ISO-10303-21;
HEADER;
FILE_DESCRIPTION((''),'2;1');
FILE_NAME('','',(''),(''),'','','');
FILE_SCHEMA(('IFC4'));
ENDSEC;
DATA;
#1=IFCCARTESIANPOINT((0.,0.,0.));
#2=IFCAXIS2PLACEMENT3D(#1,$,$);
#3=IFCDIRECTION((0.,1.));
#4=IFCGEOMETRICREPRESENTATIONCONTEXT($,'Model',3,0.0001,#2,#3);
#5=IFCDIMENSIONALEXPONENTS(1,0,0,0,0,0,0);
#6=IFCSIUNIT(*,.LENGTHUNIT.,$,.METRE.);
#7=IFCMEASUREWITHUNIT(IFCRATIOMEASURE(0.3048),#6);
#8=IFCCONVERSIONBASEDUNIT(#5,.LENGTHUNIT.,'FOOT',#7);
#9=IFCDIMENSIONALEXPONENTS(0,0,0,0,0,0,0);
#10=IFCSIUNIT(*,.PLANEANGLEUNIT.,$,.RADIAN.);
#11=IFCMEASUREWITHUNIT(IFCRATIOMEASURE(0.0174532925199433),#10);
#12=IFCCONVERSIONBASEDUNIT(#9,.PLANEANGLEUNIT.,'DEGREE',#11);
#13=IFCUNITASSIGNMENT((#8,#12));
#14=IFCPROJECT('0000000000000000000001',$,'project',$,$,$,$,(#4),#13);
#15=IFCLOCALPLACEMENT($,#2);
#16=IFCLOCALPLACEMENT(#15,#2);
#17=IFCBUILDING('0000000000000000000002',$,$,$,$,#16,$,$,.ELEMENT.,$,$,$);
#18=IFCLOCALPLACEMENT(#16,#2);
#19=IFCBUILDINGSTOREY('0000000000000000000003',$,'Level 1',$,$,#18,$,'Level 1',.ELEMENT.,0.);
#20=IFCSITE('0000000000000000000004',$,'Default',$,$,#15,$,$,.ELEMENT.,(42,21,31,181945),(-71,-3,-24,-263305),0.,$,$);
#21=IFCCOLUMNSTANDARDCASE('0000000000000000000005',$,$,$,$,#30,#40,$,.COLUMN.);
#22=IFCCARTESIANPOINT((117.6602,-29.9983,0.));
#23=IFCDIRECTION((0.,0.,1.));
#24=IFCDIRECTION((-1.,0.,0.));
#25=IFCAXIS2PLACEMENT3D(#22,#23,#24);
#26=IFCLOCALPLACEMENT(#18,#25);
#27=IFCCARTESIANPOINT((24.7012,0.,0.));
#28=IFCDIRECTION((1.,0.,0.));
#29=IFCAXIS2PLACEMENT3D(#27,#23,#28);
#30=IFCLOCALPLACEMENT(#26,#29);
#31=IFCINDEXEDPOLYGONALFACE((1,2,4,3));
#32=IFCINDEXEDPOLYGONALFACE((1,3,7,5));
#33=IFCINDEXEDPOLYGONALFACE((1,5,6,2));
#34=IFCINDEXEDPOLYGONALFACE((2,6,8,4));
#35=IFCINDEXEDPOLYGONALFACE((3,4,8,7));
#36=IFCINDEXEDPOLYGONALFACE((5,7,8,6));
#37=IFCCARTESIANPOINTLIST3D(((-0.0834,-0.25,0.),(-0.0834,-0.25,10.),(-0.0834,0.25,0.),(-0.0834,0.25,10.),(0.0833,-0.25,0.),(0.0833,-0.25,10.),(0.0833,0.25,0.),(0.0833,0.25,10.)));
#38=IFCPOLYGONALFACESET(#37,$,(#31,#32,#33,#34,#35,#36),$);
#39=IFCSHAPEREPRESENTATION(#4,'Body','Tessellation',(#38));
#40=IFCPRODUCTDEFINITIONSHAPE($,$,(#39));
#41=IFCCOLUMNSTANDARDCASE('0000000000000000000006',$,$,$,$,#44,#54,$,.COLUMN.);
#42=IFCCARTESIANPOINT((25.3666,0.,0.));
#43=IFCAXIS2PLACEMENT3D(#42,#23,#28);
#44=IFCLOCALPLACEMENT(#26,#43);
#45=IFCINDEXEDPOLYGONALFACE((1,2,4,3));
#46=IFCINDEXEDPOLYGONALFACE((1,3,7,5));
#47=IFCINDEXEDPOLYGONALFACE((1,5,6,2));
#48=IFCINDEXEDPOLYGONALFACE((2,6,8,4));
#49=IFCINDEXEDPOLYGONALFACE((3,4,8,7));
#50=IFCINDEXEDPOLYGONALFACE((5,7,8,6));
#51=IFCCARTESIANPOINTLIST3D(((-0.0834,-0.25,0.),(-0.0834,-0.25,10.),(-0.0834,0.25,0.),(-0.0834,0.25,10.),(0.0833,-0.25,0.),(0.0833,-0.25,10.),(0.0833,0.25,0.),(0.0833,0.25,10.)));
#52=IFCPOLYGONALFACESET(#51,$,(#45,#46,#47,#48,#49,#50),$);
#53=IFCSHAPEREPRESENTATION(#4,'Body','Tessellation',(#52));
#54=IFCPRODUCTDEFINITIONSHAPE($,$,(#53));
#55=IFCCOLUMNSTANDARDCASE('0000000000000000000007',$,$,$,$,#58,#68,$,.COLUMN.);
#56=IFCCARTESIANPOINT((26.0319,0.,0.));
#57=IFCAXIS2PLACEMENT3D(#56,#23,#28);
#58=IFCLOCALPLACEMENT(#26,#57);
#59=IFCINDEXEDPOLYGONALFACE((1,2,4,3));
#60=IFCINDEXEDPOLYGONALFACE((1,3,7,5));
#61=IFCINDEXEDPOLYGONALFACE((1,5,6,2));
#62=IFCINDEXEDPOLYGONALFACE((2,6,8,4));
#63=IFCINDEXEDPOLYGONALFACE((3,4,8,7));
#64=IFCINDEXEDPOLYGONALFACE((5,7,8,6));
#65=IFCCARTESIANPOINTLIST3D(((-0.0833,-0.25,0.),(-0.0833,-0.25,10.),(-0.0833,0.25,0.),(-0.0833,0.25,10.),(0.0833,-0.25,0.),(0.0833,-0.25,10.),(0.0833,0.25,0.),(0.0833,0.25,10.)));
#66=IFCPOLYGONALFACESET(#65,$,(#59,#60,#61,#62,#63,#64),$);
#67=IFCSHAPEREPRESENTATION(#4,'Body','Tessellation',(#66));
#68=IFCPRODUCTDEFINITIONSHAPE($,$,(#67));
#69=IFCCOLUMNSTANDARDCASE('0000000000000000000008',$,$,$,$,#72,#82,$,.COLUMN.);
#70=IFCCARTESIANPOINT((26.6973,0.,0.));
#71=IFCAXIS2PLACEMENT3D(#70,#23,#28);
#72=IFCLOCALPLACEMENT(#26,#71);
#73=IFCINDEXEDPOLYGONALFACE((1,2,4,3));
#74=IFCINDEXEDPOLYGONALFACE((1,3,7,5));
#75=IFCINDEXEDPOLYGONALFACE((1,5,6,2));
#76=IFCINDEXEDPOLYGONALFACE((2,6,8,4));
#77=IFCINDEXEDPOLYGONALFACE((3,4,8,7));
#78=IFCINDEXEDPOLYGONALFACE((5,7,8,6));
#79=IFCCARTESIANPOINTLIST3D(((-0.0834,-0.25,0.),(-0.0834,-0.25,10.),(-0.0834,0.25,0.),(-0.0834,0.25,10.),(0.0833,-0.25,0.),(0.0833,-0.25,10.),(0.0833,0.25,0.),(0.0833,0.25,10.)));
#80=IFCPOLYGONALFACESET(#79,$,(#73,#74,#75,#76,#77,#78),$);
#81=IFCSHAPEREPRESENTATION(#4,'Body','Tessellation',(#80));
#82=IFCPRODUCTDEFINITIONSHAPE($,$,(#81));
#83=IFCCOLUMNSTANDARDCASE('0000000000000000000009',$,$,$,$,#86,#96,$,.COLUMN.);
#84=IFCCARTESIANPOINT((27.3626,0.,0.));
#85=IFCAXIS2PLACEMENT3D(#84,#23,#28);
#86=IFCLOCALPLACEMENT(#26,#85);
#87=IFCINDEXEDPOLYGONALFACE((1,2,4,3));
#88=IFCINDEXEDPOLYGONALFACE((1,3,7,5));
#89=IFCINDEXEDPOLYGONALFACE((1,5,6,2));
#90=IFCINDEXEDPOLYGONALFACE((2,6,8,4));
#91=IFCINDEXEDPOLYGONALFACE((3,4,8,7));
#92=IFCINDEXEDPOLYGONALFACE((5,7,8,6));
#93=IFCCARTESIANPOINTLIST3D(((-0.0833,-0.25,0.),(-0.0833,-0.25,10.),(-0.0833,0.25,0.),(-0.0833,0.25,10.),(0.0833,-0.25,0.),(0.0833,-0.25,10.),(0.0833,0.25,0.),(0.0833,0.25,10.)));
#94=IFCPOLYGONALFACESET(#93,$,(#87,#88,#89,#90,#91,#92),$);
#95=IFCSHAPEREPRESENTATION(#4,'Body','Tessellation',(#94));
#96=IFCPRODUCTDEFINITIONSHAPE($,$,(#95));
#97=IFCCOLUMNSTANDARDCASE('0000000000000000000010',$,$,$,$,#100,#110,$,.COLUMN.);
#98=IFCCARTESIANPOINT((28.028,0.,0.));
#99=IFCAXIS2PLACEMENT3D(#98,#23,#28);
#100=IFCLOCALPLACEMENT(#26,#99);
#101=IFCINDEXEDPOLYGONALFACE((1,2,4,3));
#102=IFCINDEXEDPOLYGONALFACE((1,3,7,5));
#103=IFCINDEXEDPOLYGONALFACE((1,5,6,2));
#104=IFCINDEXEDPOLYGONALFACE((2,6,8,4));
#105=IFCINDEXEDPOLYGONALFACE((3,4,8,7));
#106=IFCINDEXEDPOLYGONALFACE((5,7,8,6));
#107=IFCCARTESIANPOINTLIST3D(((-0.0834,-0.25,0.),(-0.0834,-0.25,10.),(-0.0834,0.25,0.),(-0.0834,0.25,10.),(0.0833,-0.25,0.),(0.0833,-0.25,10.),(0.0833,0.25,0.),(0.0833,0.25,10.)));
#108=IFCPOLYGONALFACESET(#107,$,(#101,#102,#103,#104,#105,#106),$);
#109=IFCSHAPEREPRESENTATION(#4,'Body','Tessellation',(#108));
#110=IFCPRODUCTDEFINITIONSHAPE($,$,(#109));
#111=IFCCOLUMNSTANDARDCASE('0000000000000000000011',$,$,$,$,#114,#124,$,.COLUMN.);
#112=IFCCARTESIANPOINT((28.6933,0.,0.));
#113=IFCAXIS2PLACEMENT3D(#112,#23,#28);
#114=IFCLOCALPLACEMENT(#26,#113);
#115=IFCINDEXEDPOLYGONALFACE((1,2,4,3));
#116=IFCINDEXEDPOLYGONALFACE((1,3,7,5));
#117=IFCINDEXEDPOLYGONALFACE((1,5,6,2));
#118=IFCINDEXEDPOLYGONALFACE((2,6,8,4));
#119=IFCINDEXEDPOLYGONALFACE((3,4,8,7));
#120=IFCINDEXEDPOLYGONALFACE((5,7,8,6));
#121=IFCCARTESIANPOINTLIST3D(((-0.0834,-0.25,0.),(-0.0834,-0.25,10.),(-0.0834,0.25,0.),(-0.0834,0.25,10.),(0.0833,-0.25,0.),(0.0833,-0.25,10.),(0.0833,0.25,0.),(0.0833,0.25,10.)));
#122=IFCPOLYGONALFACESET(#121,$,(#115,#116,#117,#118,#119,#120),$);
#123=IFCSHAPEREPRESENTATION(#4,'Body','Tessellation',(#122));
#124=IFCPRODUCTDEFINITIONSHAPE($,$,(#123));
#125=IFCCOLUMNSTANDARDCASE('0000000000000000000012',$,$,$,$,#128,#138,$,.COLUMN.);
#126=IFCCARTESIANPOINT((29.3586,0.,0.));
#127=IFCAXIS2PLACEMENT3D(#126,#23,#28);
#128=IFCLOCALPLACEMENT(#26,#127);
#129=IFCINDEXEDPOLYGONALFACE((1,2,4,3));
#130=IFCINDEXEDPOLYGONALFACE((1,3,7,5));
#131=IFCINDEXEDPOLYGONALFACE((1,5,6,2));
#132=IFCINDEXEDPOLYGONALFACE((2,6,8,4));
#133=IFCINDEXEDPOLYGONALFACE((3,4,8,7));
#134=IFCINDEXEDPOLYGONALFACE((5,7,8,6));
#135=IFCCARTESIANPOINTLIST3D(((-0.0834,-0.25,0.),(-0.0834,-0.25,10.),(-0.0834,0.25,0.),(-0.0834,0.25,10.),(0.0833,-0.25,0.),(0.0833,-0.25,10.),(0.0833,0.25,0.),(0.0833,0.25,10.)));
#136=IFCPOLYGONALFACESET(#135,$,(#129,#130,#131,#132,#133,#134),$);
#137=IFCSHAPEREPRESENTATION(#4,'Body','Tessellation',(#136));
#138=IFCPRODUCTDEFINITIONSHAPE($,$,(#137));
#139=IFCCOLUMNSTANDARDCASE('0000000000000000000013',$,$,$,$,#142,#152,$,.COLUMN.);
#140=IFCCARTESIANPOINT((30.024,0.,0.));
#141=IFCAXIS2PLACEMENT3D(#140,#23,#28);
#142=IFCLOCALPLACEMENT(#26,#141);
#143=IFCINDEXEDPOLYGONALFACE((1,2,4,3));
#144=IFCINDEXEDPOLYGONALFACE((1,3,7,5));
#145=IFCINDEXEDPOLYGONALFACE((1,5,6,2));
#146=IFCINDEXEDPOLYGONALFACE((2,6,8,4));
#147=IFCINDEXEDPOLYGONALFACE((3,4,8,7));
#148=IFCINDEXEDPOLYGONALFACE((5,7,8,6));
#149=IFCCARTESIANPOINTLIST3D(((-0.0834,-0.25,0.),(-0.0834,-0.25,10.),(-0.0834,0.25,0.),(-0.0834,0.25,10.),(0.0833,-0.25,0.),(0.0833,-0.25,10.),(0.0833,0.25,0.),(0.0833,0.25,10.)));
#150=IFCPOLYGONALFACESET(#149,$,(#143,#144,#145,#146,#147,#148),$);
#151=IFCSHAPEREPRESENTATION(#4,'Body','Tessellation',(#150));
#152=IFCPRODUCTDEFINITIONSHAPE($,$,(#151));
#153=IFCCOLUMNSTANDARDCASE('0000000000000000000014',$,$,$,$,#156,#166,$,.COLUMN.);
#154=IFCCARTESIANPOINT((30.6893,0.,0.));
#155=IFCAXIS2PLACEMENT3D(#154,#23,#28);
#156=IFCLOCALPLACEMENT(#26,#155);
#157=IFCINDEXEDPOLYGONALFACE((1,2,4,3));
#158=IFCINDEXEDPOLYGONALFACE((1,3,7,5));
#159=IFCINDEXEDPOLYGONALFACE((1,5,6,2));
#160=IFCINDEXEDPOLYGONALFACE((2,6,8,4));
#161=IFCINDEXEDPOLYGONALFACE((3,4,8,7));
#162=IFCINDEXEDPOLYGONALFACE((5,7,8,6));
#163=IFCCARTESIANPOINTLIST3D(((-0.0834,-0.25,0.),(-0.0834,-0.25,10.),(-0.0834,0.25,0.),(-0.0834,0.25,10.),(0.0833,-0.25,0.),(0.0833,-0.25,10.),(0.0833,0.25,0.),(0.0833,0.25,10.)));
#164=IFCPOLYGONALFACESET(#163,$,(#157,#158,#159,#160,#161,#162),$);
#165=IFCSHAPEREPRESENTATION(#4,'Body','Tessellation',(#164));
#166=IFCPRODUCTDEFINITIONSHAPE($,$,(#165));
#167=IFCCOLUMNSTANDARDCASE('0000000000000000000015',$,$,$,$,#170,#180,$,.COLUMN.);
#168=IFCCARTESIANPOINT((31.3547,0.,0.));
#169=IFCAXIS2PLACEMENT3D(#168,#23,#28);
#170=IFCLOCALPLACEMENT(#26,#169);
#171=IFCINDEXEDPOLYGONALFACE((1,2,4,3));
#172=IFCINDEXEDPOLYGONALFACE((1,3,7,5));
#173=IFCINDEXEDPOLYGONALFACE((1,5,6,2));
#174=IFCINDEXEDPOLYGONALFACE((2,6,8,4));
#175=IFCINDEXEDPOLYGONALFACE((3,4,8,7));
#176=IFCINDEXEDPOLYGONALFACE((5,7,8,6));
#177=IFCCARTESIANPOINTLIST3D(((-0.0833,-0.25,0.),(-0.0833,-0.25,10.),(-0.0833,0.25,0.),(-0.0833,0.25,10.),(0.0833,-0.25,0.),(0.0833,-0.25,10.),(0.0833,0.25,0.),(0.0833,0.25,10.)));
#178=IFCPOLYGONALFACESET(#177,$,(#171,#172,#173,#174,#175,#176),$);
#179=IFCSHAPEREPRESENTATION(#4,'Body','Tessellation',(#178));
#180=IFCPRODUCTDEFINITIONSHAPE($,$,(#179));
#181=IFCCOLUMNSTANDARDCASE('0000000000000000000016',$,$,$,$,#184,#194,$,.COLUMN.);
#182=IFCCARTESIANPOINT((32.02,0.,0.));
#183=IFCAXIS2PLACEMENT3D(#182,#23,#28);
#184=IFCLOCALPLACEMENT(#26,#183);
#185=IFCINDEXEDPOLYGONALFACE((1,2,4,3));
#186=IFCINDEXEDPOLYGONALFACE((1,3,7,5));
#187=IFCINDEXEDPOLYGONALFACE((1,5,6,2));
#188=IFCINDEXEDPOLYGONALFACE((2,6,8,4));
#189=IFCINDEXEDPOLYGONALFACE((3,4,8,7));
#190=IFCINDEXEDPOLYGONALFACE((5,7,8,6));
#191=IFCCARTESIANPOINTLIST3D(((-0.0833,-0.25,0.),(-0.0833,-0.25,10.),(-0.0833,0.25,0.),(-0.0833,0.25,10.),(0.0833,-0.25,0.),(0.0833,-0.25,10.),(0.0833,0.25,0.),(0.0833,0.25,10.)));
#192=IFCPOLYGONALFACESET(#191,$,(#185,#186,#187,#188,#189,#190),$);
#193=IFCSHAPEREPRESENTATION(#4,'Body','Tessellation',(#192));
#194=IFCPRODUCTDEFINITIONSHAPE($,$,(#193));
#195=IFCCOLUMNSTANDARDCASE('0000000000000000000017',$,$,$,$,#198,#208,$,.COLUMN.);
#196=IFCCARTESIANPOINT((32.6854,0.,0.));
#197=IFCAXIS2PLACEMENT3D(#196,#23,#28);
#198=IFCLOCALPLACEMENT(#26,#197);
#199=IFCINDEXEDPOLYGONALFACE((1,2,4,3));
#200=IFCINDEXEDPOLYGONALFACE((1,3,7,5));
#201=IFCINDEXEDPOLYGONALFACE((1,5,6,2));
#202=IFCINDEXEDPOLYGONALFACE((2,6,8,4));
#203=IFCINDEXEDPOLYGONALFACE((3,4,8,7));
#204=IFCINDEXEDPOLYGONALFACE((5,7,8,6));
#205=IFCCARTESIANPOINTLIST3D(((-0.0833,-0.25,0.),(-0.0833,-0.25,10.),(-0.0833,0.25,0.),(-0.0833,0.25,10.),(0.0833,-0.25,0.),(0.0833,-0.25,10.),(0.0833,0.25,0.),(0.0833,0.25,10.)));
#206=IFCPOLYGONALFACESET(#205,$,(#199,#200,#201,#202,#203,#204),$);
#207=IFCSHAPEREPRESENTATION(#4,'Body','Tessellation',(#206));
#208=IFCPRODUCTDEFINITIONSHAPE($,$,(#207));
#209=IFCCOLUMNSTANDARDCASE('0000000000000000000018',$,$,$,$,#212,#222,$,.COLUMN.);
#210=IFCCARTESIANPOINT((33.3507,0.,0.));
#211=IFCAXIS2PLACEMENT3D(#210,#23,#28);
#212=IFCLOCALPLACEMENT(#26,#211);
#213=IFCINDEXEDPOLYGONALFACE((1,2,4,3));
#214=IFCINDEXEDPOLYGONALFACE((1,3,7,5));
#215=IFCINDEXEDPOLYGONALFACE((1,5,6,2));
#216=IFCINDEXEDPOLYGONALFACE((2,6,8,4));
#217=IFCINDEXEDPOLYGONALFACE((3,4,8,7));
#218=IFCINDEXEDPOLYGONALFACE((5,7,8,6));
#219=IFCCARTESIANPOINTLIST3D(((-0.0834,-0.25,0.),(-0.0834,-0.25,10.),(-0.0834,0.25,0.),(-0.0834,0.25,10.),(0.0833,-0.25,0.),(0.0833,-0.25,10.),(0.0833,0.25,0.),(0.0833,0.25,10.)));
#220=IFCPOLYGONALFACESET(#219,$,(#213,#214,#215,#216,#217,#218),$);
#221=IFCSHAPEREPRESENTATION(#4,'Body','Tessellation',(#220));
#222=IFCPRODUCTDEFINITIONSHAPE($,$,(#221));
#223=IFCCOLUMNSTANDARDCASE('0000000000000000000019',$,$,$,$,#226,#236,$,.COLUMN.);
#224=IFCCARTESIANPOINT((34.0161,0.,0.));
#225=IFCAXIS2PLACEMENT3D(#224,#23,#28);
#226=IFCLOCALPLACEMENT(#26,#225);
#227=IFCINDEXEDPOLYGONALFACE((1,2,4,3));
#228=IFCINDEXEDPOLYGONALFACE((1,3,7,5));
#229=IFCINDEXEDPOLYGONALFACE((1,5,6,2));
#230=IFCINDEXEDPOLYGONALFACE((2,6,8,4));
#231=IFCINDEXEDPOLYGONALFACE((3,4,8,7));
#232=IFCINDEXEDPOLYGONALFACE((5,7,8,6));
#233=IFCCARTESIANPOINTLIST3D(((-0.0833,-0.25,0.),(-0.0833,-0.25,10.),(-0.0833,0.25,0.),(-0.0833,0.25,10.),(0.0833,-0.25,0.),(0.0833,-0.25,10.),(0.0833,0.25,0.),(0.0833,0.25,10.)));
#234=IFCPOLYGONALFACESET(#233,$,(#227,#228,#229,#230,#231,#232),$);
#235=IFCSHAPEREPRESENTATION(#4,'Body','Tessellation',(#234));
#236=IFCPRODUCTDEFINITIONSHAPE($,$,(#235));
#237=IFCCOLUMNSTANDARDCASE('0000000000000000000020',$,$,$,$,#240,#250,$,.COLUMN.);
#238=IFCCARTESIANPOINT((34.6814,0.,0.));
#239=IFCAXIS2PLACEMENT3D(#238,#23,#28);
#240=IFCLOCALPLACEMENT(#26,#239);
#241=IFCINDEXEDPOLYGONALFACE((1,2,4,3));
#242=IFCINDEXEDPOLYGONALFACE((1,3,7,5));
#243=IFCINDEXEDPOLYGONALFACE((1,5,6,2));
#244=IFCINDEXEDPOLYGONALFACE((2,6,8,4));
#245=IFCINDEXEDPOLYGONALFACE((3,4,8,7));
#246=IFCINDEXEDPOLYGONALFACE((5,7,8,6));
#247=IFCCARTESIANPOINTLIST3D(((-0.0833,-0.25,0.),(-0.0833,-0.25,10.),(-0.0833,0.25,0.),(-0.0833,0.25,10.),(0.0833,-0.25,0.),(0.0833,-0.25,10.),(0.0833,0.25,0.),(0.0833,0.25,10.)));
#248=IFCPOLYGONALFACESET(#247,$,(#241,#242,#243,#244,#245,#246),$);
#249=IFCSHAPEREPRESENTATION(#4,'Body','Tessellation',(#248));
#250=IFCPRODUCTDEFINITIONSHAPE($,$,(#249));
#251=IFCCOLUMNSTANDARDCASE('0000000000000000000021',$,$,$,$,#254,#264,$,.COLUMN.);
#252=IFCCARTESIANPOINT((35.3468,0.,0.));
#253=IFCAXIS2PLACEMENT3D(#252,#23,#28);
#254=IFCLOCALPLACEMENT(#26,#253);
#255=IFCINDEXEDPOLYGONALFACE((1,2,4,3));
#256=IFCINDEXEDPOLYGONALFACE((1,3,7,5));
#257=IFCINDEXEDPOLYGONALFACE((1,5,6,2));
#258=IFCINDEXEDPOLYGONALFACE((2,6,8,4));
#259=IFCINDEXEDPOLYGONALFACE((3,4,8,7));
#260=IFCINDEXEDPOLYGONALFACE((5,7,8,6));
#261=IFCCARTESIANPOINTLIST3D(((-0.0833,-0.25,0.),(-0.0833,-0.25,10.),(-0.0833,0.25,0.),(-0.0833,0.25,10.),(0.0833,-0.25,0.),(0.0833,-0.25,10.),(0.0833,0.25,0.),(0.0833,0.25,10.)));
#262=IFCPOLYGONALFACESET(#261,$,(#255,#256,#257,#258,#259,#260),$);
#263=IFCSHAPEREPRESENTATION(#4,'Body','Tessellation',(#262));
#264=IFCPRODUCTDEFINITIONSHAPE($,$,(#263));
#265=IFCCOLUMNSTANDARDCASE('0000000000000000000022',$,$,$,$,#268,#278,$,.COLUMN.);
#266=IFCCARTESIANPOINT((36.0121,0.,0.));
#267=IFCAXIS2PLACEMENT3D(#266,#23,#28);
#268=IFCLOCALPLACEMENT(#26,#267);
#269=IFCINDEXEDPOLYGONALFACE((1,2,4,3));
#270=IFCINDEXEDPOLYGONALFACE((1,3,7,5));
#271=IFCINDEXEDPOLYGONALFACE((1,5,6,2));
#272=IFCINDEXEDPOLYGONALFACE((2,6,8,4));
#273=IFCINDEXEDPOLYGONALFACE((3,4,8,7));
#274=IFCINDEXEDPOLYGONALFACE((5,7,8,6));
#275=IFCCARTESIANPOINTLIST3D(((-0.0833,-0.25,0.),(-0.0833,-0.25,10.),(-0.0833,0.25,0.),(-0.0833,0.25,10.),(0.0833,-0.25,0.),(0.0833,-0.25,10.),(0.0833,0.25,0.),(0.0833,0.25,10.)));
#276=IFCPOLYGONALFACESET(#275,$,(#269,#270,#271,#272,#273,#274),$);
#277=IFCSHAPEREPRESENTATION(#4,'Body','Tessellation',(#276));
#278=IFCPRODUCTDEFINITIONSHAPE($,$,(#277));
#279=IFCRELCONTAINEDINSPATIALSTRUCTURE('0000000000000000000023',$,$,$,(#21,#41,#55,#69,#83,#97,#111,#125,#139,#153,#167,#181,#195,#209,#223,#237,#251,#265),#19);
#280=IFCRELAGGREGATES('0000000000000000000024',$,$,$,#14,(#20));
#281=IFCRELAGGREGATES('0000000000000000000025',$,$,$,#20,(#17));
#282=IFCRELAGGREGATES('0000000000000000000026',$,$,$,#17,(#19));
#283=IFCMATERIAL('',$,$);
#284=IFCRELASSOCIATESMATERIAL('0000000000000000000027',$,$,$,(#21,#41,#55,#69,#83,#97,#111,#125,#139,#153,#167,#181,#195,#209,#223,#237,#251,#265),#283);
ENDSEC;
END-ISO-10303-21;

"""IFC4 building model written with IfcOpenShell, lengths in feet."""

from ifc_helpers import new_model, entity, si_unit, converted_unit, direction, frame, origin, place, context, project, spatial, rectangle, extrude, material, element, save


model = new_model("IFC4")

# Units and contexts
model_context = context("Model", 3, precision=0.0001, world=origin(), true_north=direction((0.0, 1.0)))
ifc_project = project(units=[converted_unit("LENGTHUNIT", "FOOT", entity("IfcRatioMeasure", 0.3048), si_unit("LENGTHUNIT", "METRE"), dimensions=[1, 0, 0, 0, 0, 0, 0]), converted_unit("PLANEANGLEUNIT", "DEGREE", entity("IfcRatioMeasure", 0.0174532925199433), si_unit("PLANEANGLEUNIT", "RADIAN"), dimensions=[0, 0, 0, 0, 0, 0, 0])], contexts=[model_context])

# Site, building, storey
site_placement = place(None, origin())
site = spatial("IfcSite", under=ifc_project, at=site_placement, Name="Default", CompositionType="ELEMENT", RefLatitude=(42, 21, 31, 181945), RefLongitude=(-71, -3, -24, -263305), RefElevation=0.0)
building_placement = place(site_placement, origin())
building = spatial("IfcBuilding", under=site, at=building_placement, CompositionType="ELEMENT")
storey_placement = place(building_placement, origin())
storey = spatial("IfcBuildingStorey", under=building, at=storey_placement, Name="Level 1", LongName="Level 1", CompositionType="ELEMENT", Elevation=0.0)

# Columns
ifc_material = material(Name="")
placement = place(storey_placement, frame((117.6602, -29.9983, 0.0), z_axis=(0.0, 0.0, 1.0), x_axis=(-1.0, 0.0, 0.0)))
for number, where, z_axis, x_axis in (
    (1, (24.7012, 0.0, 0.0), (0.0, 0.0, 1.0), (1.0, 0.0, 0.0)),
    (2, (25.3666, 0.0, 0.0), (0.0, 0.0, 1.0), (1.0, 0.0, 0.0)),
    (3, (26.0319, 0.0, 0.0), (0.0, 0.0, 1.0), (1.0, 0.0, 0.0)),
    (4, (26.6973, 0.0, 0.0), (0.0, 0.0, 1.0), (1.0, 0.0, 0.0)),
    (5, (27.3626, 0.0, 0.0), (0.0, 0.0, 1.0), (1.0, 0.0, 0.0)),
    (6, (28.028, 0.0, 0.0), (0.0, 0.0, 1.0), (1.0, 0.0, 0.0)),
    (7, (28.6933, 0.0, 0.0), (0.0, 0.0, 1.0), (1.0, 0.0, 0.0)),
    (8, (29.3586, 0.0, 0.0), (0.0, 0.0, 1.0), (1.0, 0.0, 0.0)),
    (9, (30.024, 0.0, 0.0), (0.0, 0.0, 1.0), (1.0, 0.0, 0.0)),
    (10, (30.6893, 0.0, 0.0), (0.0, 0.0, 1.0), (1.0, 0.0, 0.0)),
    (11, (31.3547, 0.0, 0.0), (0.0, 0.0, 1.0), (1.0, 0.0, 0.0)),
    (12, (32.02, 0.0, 0.0), (0.0, 0.0, 1.0), (1.0, 0.0, 0.0)),
    (13, (32.6854, 0.0, 0.0), (0.0, 0.0, 1.0), (1.0, 0.0, 0.0)),
    (14, (33.3507, 0.0, 0.0), (0.0, 0.0, 1.0), (1.0, 0.0, 0.0)),
    (15, (34.0161, 0.0, 0.0), (0.0, 0.0, 1.0), (1.0, 0.0, 0.0)),
    (16, (34.6814, 0.0, 0.0), (0.0, 0.0, 1.0), (1.0, 0.0, 0.0)),
    (17, (35.3468, 0.0, 0.0), (0.0, 0.0, 1.0), (1.0, 0.0, 0.0)),
    (18, (36.0121, 0.0, 0.0), (0.0, 0.0, 1.0), (1.0, 0.0, 0.0)),
):
    element("IfcColumnStandardCase", number, at=place(placement, frame(where, z_axis=z_axis, x_axis=x_axis)), inside=storey, material=ifc_material, PredefinedType="COLUMN", context=model_context, shape_type="SweptSolid", body=[
        extrude(rectangle(XDim=0.1667, YDim=0.5), origin(), (0.0, 0.0, 1.0), 10.0),
    ])

save(model, "model.ifc")
